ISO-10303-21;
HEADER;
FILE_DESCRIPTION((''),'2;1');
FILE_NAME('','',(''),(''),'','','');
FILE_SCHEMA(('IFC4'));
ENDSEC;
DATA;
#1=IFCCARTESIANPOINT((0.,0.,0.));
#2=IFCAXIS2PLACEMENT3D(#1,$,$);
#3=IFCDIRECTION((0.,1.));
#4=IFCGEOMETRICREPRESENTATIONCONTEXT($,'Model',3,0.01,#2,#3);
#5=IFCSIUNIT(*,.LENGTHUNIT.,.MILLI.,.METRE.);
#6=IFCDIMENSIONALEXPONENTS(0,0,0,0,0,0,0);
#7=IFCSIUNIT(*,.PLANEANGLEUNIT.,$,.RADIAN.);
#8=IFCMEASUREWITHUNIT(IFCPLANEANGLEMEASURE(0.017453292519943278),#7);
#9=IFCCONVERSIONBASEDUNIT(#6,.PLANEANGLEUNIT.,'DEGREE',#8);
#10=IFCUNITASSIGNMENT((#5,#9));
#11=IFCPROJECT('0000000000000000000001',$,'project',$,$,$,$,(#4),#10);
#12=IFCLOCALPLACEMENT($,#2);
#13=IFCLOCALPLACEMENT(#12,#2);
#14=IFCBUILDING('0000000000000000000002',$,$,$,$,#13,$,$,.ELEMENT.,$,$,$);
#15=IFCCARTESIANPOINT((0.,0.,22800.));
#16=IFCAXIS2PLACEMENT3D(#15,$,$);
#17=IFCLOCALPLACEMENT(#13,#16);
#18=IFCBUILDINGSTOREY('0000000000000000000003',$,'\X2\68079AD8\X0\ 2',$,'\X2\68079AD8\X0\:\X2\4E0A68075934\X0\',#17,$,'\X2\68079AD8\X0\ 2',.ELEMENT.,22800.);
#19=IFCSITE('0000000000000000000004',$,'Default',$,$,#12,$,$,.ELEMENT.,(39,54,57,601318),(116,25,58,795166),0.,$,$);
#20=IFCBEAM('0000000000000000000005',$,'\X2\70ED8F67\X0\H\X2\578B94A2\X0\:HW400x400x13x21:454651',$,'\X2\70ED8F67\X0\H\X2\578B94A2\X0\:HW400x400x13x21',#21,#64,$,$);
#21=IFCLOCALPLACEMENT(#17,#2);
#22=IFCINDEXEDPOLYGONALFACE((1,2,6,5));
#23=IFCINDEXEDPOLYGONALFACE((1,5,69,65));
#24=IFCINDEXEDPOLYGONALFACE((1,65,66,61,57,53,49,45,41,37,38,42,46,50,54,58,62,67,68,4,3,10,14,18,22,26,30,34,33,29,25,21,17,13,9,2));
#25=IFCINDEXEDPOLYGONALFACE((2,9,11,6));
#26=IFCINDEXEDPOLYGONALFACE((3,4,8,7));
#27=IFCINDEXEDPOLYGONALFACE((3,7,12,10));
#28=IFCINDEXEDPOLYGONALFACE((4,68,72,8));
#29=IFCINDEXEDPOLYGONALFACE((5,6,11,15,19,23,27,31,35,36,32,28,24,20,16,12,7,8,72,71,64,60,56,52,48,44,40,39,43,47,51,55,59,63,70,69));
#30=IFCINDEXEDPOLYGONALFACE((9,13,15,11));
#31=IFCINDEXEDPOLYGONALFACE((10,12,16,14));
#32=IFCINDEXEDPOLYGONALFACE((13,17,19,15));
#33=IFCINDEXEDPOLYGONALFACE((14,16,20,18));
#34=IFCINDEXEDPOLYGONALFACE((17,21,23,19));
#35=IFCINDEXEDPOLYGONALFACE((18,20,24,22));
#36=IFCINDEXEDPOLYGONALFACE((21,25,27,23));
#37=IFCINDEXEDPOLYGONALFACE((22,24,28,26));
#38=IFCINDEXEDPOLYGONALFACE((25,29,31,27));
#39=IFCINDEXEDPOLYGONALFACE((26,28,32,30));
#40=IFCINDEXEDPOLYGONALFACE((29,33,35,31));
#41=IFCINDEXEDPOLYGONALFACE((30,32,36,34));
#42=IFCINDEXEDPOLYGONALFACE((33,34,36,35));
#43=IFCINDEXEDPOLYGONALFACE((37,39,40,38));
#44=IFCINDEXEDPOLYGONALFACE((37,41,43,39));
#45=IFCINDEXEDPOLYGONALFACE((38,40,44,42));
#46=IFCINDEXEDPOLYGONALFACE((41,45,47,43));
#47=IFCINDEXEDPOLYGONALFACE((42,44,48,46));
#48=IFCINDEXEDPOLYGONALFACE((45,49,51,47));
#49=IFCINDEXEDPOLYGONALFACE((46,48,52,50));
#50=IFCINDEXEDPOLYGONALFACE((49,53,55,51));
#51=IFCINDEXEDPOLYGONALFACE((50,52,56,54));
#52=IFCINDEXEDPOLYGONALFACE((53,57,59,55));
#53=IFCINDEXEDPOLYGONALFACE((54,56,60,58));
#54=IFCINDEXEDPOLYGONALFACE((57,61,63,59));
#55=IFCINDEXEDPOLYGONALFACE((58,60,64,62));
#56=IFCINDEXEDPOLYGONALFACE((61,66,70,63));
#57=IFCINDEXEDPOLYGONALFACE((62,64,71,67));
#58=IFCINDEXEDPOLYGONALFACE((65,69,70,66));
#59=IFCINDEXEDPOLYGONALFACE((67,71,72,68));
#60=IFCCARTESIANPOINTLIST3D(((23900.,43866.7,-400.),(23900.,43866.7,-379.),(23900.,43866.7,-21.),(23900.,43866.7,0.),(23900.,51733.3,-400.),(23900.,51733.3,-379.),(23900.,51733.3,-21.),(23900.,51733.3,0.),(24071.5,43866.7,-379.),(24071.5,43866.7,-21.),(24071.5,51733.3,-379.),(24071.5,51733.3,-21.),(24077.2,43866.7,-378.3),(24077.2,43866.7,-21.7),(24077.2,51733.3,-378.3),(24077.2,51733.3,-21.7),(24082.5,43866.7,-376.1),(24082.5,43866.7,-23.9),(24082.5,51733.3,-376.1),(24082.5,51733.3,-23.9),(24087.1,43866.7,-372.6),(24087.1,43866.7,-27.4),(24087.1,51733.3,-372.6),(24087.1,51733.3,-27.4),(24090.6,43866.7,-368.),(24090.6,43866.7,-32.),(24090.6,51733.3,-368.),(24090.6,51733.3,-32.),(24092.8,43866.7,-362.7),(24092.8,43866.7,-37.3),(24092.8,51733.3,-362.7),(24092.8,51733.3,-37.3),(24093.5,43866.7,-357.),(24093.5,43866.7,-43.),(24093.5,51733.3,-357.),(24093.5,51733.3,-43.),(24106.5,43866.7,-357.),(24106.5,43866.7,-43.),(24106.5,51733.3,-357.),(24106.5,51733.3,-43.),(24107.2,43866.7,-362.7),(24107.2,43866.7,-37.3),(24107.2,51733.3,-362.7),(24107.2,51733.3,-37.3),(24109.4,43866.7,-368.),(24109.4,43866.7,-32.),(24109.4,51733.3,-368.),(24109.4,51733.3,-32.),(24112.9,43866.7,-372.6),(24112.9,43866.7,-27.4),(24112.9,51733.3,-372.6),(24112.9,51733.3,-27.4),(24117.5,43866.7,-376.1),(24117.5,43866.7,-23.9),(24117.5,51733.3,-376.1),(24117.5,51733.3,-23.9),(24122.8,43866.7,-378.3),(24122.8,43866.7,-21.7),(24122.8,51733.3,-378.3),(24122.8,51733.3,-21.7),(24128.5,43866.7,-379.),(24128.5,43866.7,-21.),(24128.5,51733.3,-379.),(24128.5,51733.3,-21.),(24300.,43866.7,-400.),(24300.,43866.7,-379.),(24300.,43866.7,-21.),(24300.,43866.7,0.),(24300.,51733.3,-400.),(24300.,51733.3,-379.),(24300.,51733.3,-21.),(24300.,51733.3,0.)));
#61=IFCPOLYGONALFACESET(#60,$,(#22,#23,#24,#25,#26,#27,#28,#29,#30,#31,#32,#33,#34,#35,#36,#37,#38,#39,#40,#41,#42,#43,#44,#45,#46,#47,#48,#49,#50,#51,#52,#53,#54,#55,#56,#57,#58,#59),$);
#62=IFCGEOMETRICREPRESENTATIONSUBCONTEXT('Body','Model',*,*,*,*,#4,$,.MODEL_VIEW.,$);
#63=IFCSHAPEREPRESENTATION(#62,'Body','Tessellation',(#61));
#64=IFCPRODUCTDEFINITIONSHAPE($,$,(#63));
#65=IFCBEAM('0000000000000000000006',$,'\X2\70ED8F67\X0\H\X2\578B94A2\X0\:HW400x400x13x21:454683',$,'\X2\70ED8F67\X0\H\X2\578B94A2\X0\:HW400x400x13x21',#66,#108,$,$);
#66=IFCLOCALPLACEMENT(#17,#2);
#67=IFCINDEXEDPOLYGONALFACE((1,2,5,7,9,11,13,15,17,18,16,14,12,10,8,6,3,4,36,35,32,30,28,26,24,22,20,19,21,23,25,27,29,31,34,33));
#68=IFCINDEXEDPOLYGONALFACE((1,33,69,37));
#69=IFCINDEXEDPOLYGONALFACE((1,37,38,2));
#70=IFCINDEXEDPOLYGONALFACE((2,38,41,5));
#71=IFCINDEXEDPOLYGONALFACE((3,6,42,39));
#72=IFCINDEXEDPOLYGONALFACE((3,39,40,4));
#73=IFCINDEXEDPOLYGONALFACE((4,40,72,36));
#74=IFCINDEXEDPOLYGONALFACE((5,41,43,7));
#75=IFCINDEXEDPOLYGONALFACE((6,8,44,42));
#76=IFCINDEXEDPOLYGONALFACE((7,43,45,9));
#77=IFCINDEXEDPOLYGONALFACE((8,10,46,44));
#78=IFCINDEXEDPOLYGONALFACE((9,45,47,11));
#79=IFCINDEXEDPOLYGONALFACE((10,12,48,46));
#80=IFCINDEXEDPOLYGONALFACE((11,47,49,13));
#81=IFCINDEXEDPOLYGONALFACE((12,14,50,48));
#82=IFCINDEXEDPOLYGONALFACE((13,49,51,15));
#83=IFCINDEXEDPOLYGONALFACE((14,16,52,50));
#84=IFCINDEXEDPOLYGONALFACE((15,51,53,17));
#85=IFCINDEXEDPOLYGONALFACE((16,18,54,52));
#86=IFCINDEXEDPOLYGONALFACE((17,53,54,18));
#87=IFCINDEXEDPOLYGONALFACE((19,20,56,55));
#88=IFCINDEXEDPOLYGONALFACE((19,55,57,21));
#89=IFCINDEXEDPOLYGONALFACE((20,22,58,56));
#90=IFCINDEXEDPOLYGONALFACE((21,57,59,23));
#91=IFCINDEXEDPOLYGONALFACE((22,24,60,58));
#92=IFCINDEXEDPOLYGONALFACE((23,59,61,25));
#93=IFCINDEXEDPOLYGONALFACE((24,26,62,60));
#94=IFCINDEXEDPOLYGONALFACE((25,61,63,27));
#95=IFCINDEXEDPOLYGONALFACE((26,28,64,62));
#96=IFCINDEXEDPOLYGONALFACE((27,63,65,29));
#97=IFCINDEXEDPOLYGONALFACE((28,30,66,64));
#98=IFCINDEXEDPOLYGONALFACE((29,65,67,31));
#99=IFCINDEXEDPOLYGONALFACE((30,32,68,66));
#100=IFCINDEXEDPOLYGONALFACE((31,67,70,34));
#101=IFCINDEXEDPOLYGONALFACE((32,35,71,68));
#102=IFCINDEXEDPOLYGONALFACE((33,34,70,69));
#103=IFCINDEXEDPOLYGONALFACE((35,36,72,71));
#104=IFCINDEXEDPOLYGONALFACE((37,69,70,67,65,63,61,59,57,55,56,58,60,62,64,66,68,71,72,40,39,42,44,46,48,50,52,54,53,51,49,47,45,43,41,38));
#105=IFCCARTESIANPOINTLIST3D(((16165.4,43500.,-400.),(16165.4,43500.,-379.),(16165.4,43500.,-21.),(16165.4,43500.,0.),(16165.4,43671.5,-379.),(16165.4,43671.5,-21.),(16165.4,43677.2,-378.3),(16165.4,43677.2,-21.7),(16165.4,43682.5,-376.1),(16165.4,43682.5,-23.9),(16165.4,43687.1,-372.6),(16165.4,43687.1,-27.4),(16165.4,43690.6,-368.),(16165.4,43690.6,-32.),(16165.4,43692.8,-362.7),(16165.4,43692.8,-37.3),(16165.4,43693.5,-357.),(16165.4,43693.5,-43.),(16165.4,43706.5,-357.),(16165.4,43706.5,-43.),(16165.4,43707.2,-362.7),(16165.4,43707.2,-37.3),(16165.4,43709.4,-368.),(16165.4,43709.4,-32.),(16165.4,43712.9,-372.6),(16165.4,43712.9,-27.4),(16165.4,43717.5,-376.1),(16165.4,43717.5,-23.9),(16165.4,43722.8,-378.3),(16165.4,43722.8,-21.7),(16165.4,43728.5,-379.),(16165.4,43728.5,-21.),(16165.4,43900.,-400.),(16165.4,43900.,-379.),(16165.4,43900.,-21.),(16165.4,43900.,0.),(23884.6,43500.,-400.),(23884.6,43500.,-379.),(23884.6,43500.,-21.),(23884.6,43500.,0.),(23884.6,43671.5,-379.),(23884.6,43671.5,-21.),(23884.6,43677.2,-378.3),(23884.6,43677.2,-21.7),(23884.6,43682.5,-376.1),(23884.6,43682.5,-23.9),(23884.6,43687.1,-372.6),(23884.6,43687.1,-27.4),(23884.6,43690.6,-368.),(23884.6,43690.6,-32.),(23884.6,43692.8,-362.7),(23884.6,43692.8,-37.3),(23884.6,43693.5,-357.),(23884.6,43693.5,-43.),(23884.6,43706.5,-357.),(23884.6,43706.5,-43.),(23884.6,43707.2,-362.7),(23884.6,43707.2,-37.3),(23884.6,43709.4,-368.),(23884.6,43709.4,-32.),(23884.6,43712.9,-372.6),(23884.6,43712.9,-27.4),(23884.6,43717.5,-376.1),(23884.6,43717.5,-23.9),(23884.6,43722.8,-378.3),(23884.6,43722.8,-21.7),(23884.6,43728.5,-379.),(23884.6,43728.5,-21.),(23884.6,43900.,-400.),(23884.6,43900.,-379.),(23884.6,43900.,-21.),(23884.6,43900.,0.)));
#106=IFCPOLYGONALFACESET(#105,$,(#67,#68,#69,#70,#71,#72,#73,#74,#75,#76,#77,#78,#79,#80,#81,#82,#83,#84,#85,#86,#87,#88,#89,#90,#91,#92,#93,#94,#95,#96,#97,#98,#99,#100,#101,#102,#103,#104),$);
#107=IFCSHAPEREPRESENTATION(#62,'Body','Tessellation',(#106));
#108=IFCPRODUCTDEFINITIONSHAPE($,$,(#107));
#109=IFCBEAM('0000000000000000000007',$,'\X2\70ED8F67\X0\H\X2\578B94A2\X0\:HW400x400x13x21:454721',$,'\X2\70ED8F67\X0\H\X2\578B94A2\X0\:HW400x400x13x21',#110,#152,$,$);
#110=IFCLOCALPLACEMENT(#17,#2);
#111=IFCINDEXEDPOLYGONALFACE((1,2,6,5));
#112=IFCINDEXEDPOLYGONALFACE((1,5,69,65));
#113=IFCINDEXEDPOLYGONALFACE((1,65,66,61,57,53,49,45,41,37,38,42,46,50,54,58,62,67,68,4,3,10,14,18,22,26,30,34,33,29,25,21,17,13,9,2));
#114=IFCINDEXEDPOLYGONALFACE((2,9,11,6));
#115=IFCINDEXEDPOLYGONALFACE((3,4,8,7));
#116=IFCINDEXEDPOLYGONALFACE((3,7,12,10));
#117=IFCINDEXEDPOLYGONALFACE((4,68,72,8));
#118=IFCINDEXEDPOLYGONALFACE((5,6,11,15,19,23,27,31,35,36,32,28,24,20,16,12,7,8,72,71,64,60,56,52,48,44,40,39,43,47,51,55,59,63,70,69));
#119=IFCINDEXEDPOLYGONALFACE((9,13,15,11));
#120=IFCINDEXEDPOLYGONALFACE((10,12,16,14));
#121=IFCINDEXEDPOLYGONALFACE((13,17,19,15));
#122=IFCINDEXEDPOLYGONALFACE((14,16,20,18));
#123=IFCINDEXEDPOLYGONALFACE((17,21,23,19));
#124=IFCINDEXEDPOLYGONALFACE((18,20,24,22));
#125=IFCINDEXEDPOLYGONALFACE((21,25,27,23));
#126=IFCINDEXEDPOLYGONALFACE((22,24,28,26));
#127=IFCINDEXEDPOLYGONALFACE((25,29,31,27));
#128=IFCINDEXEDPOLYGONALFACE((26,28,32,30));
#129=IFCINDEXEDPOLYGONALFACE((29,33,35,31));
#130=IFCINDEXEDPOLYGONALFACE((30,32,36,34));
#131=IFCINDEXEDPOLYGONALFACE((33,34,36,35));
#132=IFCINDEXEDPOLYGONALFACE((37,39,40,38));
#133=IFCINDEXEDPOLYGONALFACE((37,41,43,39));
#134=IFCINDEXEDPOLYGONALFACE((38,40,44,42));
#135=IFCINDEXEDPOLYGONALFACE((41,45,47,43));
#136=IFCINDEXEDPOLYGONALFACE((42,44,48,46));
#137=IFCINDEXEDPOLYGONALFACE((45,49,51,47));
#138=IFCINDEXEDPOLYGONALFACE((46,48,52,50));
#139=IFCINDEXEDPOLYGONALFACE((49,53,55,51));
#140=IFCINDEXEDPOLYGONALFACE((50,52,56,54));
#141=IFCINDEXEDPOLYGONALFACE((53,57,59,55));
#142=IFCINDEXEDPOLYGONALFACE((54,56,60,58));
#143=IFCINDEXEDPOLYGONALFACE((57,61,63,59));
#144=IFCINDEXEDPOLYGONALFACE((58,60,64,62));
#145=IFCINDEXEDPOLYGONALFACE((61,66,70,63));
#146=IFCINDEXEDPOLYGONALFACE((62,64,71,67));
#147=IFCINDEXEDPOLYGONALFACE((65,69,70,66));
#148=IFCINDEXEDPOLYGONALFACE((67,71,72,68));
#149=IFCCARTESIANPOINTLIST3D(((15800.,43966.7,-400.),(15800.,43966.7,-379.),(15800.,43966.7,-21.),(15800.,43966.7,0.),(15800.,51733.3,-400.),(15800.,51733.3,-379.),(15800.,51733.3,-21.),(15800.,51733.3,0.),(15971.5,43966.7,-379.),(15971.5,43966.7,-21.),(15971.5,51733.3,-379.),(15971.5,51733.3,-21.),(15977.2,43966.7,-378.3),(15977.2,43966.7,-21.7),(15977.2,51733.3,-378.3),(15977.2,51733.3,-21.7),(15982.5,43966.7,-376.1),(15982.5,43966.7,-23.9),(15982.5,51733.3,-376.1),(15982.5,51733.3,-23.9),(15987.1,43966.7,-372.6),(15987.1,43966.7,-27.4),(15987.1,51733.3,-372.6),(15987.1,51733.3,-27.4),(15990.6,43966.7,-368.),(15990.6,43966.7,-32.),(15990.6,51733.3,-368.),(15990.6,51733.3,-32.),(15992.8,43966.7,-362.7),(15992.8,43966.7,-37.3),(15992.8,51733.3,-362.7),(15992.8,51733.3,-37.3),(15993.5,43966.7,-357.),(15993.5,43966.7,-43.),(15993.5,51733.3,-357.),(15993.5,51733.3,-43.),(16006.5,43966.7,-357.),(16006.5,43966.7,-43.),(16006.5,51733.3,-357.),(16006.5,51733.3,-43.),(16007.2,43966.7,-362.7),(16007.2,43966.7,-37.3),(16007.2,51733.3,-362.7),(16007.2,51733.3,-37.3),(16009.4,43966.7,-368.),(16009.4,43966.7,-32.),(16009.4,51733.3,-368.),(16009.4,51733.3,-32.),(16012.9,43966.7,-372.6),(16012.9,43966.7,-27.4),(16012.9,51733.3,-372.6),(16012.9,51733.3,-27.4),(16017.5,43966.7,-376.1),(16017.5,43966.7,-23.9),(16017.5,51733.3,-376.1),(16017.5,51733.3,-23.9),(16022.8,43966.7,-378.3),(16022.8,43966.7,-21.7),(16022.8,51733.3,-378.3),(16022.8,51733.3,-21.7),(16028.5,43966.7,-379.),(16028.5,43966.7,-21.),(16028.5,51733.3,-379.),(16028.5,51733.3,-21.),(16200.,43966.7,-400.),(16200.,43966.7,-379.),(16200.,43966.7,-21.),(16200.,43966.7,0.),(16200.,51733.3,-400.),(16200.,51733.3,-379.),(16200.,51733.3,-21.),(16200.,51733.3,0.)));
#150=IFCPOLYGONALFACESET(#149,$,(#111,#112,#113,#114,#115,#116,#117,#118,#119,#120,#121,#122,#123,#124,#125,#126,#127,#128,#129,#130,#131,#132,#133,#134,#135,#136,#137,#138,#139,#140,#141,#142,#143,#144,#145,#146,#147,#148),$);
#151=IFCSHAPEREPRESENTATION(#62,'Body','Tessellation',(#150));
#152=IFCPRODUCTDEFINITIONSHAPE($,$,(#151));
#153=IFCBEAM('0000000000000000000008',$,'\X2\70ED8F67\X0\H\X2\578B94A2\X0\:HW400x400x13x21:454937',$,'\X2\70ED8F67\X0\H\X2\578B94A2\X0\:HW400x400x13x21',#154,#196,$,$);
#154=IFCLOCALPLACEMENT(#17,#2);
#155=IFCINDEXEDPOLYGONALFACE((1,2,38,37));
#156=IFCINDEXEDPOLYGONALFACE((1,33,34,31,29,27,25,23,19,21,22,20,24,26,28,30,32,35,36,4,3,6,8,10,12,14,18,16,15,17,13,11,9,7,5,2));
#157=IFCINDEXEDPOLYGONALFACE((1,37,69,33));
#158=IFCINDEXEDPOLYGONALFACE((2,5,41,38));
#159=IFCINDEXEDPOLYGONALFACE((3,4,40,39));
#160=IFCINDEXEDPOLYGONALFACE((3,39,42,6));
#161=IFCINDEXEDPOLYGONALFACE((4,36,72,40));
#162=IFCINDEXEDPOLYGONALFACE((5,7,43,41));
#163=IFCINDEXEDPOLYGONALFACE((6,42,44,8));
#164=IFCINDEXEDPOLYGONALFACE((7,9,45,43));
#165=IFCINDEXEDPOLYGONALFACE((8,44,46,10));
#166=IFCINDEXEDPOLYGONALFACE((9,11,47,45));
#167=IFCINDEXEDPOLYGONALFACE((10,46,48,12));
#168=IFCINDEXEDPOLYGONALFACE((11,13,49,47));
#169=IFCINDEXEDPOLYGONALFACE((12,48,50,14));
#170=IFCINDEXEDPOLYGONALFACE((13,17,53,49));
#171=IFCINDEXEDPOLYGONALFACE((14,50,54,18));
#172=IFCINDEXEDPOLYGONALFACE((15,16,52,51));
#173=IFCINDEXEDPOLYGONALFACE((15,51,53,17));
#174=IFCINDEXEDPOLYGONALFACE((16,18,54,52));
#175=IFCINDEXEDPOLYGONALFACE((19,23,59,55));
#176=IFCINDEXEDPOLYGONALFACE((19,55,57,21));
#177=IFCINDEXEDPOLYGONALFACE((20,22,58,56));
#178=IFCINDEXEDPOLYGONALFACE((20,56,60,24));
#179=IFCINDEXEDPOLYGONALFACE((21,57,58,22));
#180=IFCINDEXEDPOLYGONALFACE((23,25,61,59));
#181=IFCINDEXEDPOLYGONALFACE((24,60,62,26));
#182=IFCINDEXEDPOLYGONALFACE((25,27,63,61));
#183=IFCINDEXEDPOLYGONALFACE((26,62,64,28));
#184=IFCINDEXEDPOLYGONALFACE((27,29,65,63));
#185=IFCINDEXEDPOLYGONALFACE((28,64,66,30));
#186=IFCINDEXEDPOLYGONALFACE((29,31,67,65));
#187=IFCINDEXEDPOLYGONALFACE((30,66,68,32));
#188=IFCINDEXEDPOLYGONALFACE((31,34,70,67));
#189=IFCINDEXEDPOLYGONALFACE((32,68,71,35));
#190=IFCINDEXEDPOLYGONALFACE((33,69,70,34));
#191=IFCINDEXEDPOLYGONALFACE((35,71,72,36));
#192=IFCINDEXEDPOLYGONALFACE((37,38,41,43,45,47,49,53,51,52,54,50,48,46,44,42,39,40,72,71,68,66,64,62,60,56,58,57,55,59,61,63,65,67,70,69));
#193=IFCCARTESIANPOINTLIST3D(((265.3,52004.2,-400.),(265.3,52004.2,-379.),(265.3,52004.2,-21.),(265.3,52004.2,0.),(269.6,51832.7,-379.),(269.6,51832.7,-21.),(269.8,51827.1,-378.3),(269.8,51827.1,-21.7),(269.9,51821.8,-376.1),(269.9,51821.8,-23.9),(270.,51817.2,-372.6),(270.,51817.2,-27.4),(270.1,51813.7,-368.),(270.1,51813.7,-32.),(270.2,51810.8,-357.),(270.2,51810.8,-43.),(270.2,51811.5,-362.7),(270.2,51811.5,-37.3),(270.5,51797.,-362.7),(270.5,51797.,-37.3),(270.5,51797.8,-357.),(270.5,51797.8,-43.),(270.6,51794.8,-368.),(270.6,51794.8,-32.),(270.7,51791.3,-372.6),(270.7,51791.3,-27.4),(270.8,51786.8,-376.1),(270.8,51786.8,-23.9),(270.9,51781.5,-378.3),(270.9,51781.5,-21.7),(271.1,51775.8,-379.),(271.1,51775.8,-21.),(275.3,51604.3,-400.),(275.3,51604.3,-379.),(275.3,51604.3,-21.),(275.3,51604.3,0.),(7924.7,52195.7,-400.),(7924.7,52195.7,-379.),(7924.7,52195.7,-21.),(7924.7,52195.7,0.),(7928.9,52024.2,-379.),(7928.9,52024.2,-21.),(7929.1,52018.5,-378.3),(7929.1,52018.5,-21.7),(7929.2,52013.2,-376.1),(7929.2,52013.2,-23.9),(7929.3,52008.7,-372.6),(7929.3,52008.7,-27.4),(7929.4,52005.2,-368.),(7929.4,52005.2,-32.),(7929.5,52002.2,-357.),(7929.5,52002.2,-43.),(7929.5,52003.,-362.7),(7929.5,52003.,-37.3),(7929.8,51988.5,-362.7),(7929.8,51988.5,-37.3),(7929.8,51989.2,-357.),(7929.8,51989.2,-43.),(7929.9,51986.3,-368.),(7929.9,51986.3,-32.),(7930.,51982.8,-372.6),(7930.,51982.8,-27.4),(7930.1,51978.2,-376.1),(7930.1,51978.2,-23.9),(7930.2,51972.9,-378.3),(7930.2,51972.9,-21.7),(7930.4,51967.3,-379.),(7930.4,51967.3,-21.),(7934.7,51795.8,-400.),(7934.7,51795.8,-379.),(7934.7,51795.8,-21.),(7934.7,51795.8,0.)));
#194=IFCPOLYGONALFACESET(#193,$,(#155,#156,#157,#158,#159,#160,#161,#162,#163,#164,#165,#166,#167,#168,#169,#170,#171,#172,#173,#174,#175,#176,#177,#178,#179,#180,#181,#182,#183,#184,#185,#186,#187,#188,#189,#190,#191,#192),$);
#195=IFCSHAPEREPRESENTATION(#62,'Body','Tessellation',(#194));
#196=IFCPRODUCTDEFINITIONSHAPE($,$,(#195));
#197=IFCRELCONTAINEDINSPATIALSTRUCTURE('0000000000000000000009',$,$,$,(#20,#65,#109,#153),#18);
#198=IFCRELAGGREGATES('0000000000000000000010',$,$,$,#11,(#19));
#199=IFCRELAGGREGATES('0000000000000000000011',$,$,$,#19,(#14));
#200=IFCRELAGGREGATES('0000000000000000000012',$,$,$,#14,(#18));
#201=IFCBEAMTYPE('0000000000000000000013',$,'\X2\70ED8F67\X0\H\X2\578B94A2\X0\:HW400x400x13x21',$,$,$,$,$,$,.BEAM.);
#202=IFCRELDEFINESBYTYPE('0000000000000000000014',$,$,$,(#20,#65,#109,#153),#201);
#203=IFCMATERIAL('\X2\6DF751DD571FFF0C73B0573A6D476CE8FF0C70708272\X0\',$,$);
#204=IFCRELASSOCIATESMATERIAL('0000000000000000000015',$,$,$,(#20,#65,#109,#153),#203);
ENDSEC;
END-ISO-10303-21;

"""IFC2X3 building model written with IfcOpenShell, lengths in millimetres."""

from ifc_helpers import new_model, entity, si_unit, converted_unit, direction, frame, frame_2d, origin, place, context, subcontext, project, spatial, i_section, extrude, material, type_object, element, save


model = new_model("IFC2X3")

# Units and contexts
model_context = context("Model", 3, precision=0.01, world=origin(), true_north=direction((0.0, 1.0)))
body_context = subcontext(model_context, "Body", "Model", "MODEL_VIEW")
ifc_project = project(units=[si_unit("LENGTHUNIT", "METRE", prefix="MILLI"), converted_unit("PLANEANGLEUNIT", "DEGREE", entity("IfcPlaneAngleMeasure", 0.017453292519943278), si_unit("PLANEANGLEUNIT", "RADIAN"), dimensions=[0, 0, 0, 0, 0, 0, 0])], contexts=[model_context])

# Site, building, storey
site_placement = place(None, origin())
site = spatial("IfcSite", under=ifc_project, at=site_placement, Name="Default", CompositionType="ELEMENT", RefLatitude=(39, 54, 57, 601318), RefLongitude=(116, 25, 58, 795166), RefElevation=0.0)
building_placement = place(site_placement, origin())
building = spatial("IfcBuilding", under=site, at=building_placement, CompositionType="ELEMENT")
storey_placement = place(building_placement, frame((0.0, 0.0, 22800.0)))
storey = spatial("IfcBuildingStorey", under=building, at=storey_placement, Name="标高 2", ObjectType="标高:上标头", LongName="标高 2", CompositionType="ELEMENT", Elevation=22800.0)

# Beams
ifc_material = material(Name="混凝土，现场浇注，灰色")
beam_type = type_object("IfcBeamType", Name="热轧H型钢:HW400x400x13x21", PredefinedType="BEAM")
beam_1_placement = place(storey_placement, frame((24100.0, 51900.0, 0.0), z_axis=(0.0, 0.0, 1.0), x_axis=(0.0, -1.0, 0.0)))
element("IfcBeam", 1, at=beam_1_placement, inside=storey, type_object=beam_type, material=ifc_material, Name="热轧H型钢:HW400x400x13x21:454651", ObjectType="热轧H型钢:HW400x400x13x21", context=body_context, shape_type="SweptSolid", body=[
    extrude(i_section(OverallWidth=400.0, OverallDepth=400.0, WebThickness=13.0, FlangeThickness=21.0, FilletRadius=22.0, at=frame_2d((0.0, 0.0), x_axis=(0.0, 1.0))), frame((166.7, 0.0, -200.0), z_axis=(1.0, 0.0, 0.0), x_axis=(0.0, 0.0, -1.0)), (0.0, 0.0, 1.0), 7866.6),
])
beam_2_placement = place(storey_placement, frame((16000.0, 43700.0, 0.0)))
element("IfcBeam", 2, at=beam_2_placement, inside=storey, type_object=beam_type, material=ifc_material, Name="热轧H型钢:HW400x400x13x21:454683", ObjectType="热轧H型钢:HW400x400x13x21", context=body_context, shape_type="SweptSolid", body=[
    extrude(i_section(OverallWidth=400.0, OverallDepth=400.0, WebThickness=13.0, FlangeThickness=21.0, FilletRadius=22.0, at=frame_2d((0.0, 0.0), x_axis=(0.0, 1.0))), frame((165.4, 0.0, -200.0), z_axis=(1.0, 0.0, 0.0), x_axis=(0.0, 0.0, -1.0)), (0.0, 0.0, 1.0), 7719.2),
])
beam_3_placement = place(storey_placement, frame((16000.0, 51900.0, 0.0), z_axis=(0.0, 0.0, 1.0), x_axis=(0.0, -1.0, 0.0)))
element("IfcBeam", 3, at=beam_3_placement, inside=storey, type_object=beam_type, material=ifc_material, Name="热轧H型钢:HW400x400x13x21:454721", ObjectType="热轧H型钢:HW400x400x13x21", context=body_context, shape_type="SweptSolid", body=[
    extrude(i_section(OverallWidth=400.0, OverallDepth=400.0, WebThickness=13.0, FlangeThickness=21.0, FilletRadius=22.0, at=frame_2d((0.0, 0.0), x_axis=(0.0, 1.0))), frame((166.7, 0.0, -200.0), z_axis=(1.0, 0.0, 0.0), x_axis=(0.0, 0.0, -1.0)), (0.0, 0.0, 1.0), 7766.6),
])
beam_4_placement = place(storey_placement, frame((100.0, 51800.0, 0.0), z_axis=(0.0, 0.0, 1.0), x_axis=(0.999688, 0.024992, 0.0)))
element("IfcBeam", 4, at=beam_4_placement, inside=storey, type_object=beam_type, material=ifc_material, Name="热轧H型钢:HW400x400x13x21:454937", ObjectType="热轧H型钢:HW400x400x13x21", context=body_context, shape_type="SweptSolid", body=[
    extrude(i_section(OverallWidth=400.0, OverallDepth=400.0, WebThickness=13.0, FlangeThickness=21.0, FilletRadius=22.0, at=frame_2d((0.0, 0.0), x_axis=(0.0, 1.0))), frame((170.4, 0.0, -200.0), z_axis=(1.0, 0.0, 0.0), x_axis=(0.0, 0.0, -1.0)), (0.0, 0.0, 1.0), 7661.7),
])

save(model, "model.ifc")
